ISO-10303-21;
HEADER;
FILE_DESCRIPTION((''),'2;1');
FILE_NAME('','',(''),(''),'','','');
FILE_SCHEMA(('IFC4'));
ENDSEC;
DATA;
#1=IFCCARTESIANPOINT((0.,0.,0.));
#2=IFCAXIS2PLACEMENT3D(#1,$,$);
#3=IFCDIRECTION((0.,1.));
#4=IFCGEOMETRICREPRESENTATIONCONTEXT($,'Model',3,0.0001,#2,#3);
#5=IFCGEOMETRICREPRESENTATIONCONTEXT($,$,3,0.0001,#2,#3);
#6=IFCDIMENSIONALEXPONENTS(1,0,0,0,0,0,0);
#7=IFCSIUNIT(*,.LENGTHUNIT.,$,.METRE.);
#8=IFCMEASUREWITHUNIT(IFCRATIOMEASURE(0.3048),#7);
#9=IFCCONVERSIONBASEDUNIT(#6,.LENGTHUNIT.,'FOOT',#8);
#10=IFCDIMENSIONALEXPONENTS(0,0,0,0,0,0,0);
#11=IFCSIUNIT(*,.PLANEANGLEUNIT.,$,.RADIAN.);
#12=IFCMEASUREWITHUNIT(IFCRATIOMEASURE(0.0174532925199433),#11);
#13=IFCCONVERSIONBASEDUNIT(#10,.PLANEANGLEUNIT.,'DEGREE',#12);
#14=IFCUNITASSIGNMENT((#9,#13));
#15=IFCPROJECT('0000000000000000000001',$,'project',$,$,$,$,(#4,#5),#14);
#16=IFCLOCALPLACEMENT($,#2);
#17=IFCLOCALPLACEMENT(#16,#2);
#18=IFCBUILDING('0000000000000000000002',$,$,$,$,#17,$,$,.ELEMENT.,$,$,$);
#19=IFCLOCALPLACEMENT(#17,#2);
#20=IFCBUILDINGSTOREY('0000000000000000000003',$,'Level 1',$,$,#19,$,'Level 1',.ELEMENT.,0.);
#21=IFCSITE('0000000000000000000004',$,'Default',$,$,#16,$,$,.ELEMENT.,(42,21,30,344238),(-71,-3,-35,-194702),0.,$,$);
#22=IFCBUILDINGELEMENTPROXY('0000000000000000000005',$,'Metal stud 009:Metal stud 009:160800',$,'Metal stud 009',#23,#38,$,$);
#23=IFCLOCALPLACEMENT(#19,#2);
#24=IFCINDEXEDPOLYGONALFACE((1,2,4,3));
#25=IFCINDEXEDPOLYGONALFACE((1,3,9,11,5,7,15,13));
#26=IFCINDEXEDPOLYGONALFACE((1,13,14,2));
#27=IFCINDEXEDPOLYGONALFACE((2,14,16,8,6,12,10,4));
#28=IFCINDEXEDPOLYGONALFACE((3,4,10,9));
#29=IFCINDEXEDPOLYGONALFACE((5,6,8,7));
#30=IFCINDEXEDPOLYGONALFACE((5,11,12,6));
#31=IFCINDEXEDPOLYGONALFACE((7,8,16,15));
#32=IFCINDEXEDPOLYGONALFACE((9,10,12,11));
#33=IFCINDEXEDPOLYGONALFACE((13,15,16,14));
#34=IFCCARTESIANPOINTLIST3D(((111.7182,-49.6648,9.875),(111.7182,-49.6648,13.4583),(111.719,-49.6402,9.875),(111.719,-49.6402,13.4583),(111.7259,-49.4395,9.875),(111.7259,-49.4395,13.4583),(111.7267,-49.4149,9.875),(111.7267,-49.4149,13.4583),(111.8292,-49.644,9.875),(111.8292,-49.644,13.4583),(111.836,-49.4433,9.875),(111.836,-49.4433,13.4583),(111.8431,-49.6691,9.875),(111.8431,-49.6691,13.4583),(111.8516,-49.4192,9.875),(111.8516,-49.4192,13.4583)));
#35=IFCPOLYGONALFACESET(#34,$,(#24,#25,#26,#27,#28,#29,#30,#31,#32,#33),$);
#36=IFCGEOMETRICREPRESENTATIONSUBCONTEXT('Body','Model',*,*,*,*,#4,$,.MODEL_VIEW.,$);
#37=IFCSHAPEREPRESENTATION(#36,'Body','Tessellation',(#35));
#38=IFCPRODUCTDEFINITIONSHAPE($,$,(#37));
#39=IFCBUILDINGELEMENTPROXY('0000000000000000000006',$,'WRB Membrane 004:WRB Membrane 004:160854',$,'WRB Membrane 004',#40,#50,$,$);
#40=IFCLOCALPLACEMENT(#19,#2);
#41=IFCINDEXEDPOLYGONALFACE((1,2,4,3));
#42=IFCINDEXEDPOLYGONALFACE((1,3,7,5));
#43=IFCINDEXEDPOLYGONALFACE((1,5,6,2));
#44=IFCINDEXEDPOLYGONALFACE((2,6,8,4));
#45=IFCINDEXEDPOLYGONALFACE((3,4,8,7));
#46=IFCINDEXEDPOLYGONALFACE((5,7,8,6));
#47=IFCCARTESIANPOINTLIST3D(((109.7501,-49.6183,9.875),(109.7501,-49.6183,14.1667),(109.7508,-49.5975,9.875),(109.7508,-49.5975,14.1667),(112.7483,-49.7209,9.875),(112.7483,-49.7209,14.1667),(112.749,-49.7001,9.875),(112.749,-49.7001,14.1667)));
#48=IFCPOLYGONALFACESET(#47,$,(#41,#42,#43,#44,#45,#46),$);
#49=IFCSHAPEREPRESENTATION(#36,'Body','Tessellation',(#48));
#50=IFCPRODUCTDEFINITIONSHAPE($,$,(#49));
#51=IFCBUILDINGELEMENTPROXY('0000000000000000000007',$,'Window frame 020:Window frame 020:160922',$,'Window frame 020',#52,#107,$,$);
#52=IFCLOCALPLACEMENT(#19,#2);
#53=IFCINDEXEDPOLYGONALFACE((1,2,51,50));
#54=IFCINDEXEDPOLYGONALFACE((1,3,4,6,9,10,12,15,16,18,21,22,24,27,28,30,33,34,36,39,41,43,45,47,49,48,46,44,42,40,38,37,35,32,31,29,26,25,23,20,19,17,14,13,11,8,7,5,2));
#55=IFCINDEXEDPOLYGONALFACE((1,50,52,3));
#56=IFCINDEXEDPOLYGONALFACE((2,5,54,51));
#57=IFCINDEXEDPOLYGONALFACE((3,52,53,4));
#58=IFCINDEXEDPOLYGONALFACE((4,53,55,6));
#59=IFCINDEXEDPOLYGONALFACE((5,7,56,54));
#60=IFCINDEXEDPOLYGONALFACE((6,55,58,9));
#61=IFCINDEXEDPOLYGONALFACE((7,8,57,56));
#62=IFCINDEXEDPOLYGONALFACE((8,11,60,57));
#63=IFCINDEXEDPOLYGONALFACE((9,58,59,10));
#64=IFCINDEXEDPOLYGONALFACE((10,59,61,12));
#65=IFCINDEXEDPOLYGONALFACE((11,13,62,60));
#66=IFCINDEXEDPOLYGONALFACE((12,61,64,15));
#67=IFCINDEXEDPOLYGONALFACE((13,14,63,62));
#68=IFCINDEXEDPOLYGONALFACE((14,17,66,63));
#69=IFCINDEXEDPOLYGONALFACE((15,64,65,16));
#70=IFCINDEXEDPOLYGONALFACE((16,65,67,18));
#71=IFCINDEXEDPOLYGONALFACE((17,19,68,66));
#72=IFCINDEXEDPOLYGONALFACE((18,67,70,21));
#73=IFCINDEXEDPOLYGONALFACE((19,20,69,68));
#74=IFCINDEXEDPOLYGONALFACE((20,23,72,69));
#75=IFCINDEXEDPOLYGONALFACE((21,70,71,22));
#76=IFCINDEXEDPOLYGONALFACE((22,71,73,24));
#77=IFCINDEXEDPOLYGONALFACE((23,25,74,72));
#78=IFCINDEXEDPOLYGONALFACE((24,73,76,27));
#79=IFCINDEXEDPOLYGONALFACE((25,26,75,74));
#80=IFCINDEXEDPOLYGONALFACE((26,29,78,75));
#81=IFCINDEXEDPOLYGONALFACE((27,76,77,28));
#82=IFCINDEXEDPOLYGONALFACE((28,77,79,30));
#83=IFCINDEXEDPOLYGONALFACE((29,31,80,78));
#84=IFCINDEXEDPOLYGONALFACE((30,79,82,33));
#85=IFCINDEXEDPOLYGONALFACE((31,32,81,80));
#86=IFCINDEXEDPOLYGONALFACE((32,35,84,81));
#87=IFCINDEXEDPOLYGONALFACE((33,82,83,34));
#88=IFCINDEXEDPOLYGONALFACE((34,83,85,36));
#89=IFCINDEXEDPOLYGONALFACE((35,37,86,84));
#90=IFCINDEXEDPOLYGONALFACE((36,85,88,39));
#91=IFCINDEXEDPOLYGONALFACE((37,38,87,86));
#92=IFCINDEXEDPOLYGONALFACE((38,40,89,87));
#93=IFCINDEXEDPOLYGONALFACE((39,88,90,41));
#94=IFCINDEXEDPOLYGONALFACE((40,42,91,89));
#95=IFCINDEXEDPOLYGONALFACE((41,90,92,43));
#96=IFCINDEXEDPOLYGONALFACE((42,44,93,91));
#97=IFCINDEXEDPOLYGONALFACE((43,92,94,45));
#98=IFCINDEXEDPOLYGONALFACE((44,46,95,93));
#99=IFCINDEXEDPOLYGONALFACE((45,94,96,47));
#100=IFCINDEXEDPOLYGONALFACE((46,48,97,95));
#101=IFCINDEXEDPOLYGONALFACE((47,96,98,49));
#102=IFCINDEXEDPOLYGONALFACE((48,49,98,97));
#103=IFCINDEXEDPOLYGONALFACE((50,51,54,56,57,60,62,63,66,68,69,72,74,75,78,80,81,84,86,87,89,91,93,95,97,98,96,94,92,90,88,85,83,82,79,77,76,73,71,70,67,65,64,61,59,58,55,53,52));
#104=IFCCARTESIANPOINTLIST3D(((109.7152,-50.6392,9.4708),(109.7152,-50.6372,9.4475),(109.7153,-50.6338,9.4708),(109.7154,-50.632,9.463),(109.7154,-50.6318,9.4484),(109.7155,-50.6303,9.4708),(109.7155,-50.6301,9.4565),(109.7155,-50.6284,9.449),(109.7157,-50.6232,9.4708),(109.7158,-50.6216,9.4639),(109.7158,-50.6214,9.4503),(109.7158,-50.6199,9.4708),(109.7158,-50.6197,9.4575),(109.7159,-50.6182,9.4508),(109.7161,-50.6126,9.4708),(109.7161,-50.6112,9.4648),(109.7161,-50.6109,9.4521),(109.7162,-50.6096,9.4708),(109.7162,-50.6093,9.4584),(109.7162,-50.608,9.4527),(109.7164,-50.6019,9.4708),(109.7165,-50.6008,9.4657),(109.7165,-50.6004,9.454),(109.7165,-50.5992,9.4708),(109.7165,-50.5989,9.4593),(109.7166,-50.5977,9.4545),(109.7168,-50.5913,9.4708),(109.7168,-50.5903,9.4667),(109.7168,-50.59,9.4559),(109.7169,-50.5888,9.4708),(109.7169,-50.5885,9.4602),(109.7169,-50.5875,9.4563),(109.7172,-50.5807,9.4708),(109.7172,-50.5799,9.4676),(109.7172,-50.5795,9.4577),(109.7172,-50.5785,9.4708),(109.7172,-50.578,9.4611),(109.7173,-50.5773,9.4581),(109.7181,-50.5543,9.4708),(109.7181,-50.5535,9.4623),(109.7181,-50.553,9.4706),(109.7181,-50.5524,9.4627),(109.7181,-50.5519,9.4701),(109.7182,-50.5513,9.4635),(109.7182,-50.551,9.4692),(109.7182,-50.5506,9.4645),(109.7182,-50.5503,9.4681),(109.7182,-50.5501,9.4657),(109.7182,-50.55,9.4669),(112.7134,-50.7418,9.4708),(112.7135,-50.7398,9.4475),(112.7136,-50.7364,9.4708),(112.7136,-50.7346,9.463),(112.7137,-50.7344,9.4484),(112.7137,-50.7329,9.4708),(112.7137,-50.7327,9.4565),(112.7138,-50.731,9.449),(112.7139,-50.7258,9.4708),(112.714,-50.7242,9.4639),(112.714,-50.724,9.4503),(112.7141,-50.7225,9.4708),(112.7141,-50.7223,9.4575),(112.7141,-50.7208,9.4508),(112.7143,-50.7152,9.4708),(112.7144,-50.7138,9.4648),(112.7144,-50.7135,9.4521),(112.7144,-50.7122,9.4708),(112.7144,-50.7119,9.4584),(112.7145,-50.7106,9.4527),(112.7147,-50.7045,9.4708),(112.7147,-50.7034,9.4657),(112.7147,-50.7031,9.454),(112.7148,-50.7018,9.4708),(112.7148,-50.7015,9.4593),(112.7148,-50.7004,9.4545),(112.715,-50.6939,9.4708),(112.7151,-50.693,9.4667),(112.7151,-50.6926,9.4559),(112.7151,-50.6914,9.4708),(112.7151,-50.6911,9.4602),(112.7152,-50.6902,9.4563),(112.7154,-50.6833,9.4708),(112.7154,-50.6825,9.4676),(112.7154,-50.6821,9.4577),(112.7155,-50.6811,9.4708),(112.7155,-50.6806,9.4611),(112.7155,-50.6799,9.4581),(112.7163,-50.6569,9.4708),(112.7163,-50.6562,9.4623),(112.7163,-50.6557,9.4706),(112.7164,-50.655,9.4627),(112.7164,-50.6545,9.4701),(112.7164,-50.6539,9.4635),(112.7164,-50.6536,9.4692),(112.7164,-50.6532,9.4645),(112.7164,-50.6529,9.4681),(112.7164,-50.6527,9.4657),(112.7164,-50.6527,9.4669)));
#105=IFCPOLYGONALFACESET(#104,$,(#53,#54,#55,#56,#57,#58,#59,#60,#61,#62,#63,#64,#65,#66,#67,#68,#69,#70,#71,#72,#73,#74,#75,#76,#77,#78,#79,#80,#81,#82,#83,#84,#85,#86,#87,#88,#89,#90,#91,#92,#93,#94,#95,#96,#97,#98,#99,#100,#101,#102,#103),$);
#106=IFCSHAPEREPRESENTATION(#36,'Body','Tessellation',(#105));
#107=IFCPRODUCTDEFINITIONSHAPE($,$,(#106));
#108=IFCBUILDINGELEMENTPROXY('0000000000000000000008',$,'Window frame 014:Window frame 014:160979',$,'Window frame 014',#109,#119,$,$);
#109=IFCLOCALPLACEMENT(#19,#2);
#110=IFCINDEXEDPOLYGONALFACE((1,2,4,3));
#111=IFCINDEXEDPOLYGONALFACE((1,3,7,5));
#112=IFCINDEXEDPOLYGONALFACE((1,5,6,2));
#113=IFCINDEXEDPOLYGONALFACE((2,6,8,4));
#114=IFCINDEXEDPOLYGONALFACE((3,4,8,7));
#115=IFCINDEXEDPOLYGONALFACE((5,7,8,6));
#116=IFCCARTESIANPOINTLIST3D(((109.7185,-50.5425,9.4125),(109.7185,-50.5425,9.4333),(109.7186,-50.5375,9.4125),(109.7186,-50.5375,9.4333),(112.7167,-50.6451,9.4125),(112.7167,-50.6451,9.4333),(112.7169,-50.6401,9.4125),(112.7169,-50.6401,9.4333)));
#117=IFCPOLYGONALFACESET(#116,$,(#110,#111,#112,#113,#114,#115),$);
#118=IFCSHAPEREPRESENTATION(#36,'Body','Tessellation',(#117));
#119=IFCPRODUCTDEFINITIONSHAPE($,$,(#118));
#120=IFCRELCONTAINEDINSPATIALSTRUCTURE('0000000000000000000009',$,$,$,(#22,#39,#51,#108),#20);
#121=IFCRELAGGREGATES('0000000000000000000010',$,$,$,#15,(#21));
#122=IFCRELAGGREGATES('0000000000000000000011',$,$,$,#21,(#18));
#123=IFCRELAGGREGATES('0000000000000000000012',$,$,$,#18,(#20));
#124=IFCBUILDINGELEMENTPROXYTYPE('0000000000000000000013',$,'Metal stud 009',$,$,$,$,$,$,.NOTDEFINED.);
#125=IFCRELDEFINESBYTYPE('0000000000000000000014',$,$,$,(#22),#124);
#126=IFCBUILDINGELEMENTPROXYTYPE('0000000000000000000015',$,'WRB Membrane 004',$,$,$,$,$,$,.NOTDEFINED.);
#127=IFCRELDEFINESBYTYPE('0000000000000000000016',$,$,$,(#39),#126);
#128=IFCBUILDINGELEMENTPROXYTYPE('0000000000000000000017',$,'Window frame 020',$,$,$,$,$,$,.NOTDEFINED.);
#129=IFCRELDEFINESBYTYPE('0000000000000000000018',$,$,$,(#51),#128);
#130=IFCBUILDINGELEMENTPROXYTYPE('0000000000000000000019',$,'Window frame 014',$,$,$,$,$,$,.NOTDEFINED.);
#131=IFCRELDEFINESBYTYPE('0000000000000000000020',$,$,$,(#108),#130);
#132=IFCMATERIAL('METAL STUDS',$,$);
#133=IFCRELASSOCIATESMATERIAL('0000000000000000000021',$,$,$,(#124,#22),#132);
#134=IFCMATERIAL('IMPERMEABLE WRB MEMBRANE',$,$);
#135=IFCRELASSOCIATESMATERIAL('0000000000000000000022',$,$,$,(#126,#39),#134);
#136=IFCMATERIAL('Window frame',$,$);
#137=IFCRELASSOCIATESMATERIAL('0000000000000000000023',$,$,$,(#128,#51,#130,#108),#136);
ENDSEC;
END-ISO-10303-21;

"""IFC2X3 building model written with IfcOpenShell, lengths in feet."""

from ifc_helpers import new_model, entity, si_unit, converted_unit, direction, frame, frame_2d, origin, origin_2d_with_axis, place, context, subcontext, project, spatial, polyline, circle_curve, parameter, trimmed, segment, composite_curve, rectangle, outline, extrude, source, transform, mapped, material, type_object, type_shapes, element, save


model = new_model("IFC2X3")

# Units and contexts
model_context = context("Model", 3, precision=0.0001, world=origin(), true_north=direction((0.0, 1.0)))
context_of_model = context(None, 3, precision=0.0001, world=origin(), true_north=direction((0.0, 1.0)))
body_context = subcontext(model_context, "Body", "Model", "MODEL_VIEW")
ifc_project = project(units=[converted_unit("LENGTHUNIT", "FOOT", entity("IfcRatioMeasure", 0.3048), si_unit("LENGTHUNIT", "METRE"), dimensions=[1, 0, 0, 0, 0, 0, 0]), converted_unit("PLANEANGLEUNIT", "DEGREE", entity("IfcRatioMeasure", 0.0174532925199433), si_unit("PLANEANGLEUNIT", "RADIAN"), dimensions=[0, 0, 0, 0, 0, 0, 0])], contexts=[model_context, context_of_model])

# Site, building, storey
site_placement = place(None, origin())
site = spatial("IfcSite", under=ifc_project, at=site_placement, Name="Default", CompositionType="ELEMENT", RefLatitude=(42, 21, 30, 344238), RefLongitude=(-71, -3, -35, -194702), RefElevation=0.0)
building_placement = place(site_placement, origin())
building = spatial("IfcBuilding", under=site, at=building_placement, CompositionType="ELEMENT")
storey_placement = place(building_placement, origin())
storey = spatial("IfcBuildingStorey", under=building, at=storey_placement, Name="Level 1", LongName="Level 1", CompositionType="ELEMENT", Elevation=0.0)

# Building element proxies
ifc_material_1 = material(Name="METAL STUDS")
building_element_proxy_type_1 = type_object("IfcBuildingElementProxyType", Name="Metal stud 009", PredefinedType="NOTDEFINED", material=ifc_material_1)
shared_shape_1 = source(origin(), body_context, "Body", "SweptSolid", [
    extrude(outline(polyline([(-0.0662, -0.125), (0.0588, -0.125), (0.0588, -0.1004), (-0.0514, -0.1004), (-0.0514, 0.1004), (0.0588, 0.1004), (0.0588, 0.125), (-0.0662, 0.125), (-0.0662, -0.125)])), frame((111.7812, -49.5419, 9.875), z_axis=(0.0, 0.0, 1.0), x_axis=(-0.999415, 0.034202, 0.0)), (0.0, 0.0, 1.0), 3.5833),
])
type_shapes(building_element_proxy_type_1, [shared_shape_1])
proxy_1_placement = place(storey_placement, origin())
element("IfcBuildingElementProxy", 1, at=proxy_1_placement, inside=storey, type_object=building_element_proxy_type_1, material=ifc_material_1, Name="Metal stud 009:Metal stud 009:160800", ObjectType="Metal stud 009", context=body_context, shape_type="MappedRepresentation", body=[
    mapped(shared_shape_1, transform((0.0, 0.0, 0.0), scale=1.0)),
])
ifc_material_2 = material(Name="IMPERMEABLE WRB MEMBRANE")
building_element_proxy_type_2 = type_object("IfcBuildingElementProxyType", Name="WRB Membrane 004", PredefinedType="NOTDEFINED", material=ifc_material_2)
shared_shape_2 = source(origin(), body_context, "Body", "SweptSolid", [
    extrude(rectangle(XDim=3.0, YDim=0.0208, at=origin_2d_with_axis()), frame((111.2496, -49.6592, 9.875), z_axis=(0.0, 0.0, 1.0), x_axis=(-0.999415, 0.034202, 0.0)), (0.0, 0.0, 1.0), 4.2917),
])
type_shapes(building_element_proxy_type_2, [shared_shape_2])
proxy_2_placement = place(storey_placement, origin())
element("IfcBuildingElementProxy", 2, at=proxy_2_placement, inside=storey, type_object=building_element_proxy_type_2, material=ifc_material_2, Name="WRB Membrane 004:WRB Membrane 004:160854", ObjectType="WRB Membrane 004", context=body_context, shape_type="MappedRepresentation", body=[
    mapped(shared_shape_2, transform((0.0, 0.0, 0.0), scale=1.0)),
])
ifc_material_3 = material(Name="Window frame")
building_element_proxy_type_3 = type_object("IfcBuildingElementProxyType", Name="Window frame 020", PredefinedType="NOTDEFINED", material=ifc_material_3)
shared_shape_3 = source(origin(), body_context, "Body", "SweptSolid", [
    extrude(outline(composite_curve([segment(polyline([(-0.0351, -0.0087), (-0.0297, -0.0087)]), True, "CONTINUOUS"), segment(polyline([(-0.0297, -0.0087), (-0.0266, -0.001)]), True, "CONTINUOUS"), segment(polyline([(-0.0266, -0.001), (-0.0262, -0.0087)]), True, "CONTINUOUS"), segment(polyline([(-0.0262, -0.0087), (-0.0191, -0.0087)]), True, "CONTINUOUS"), segment(polyline([(-0.0191, -0.0087), (-0.0161, -0.0019)]), True, "CONTINUOUS"), segment(polyline([(-0.0161, -0.0019), (-0.0158, -0.0087)]), True, "CONTINUOUS"), segment(polyline([(-0.0158, -0.0087), (-0.0084, -0.0087)]), True, "CONTINUOUS"), segment(polyline([(-0.0084, -0.0087), (-0.0057, -0.0028)]), True, "CONTINUOUS"), segment(polyline([(-0.0057, -0.0028), (-0.0054, -0.0087)]), True, "CONTINUOUS"), segment(polyline([(-0.0054, -0.0087), (0.0022, -0.0087)]), True, "CONTINUOUS"), segment(polyline([(0.0022, -0.0087), (0.0047, -0.0037)]), True, "CONTINUOUS"), segment(polyline([(0.0047, -0.0037), (0.0049, -0.0087)]), True, "CONTINUOUS"), segment(polyline([(0.0049, -0.0087), (0.0128, -0.0087)]), True, "CONTINUOUS"), segment(polyline([(0.0128, -0.0087), (0.0151, -0.0046)]), True, "CONTINUOUS"), segment(polyline([(0.0151, -0.0046), (0.0153, -0.0087)]), True, "CONTINUOUS"), segment(polyline([(0.0153, -0.0087), (0.0235, -0.0087)]), True, "CONTINUOUS"), segment(polyline([(0.0235, -0.0087), (0.0255, -0.0056)]), True, "CONTINUOUS"), segment(polyline([(0.0255, -0.0056), (0.0257, -0.0087)]), True, "CONTINUOUS"), segment(polyline([(0.0257, -0.0087), (0.0499, -0.0087)]), True, "CONTINUOUS"), segment(trimmed(circle_curve(frame_2d((0.0499, -0.0044), x_axis=(-0.984549, 0.175111)), 0.0043), [parameter(100.085127)], [parameter(269.994873)], True, "PARAMETER"), True, "CONTINUOUS"), segment(polyline([(0.0506, -0.0002), (0.0268, 0.004)]), True, "CONTINUOUS"), segment(polyline([(0.0268, 0.004), (0.0248, 0.0011)]), True, "CONTINUOUS"), segment(polyline([(0.0248, 0.0011), (0.0246, 0.0044)]), True, "CONTINUOUS"), segment(polyline([(0.0246, 0.0044), (0.0166, 0.0058)]), True, "CONTINUOUS"), segment(polyline([(0.0166, 0.0058), (0.0144, 0.002)]), True, "CONTINUOUS"), segment(polyline([(0.0144, 0.002), (0.0142, 0.0063)]), True, "CONTINUOUS"), segment(polyline([(0.0142, 0.0063), (0.0064, 0.0077)]), True, "CONTINUOUS"), segment(polyline([(0.0064, 0.0077), (0.004, 0.003)]), True, "CONTINUOUS"), segment(polyline([(0.004, 0.003), (0.0037, 0.0081)]), True, "CONTINUOUS"), segment(polyline([(0.0037, 0.0081), (-0.0038, 0.0095)]), True, "CONTINUOUS"), segment(polyline([(-0.0038, 0.0095), (-0.0065, 0.0039)]), True, "CONTINUOUS"), segment(polyline([(-0.0065, 0.0039), (-0.0068, 0.01)]), True, "CONTINUOUS"), segment(polyline([(-0.0068, 0.01), (-0.014, 0.0113)]), True, "CONTINUOUS"), segment(polyline([(-0.014, 0.0113), (-0.0169, 0.0048)]), True, "CONTINUOUS"), segment(polyline([(-0.0169, 0.0048), (-0.0172, 0.0119)]), True, "CONTINUOUS"), segment(polyline([(-0.0172, 0.0119), (-0.0242, 0.0131)]), True, "CONTINUOUS"), segment(polyline([(-0.0242, 0.0131), (-0.0273, 0.0057)]), True, "CONTINUOUS"), segment(polyline([(-0.0273, 0.0057), (-0.0277, 0.0137)]), True, "CONTINUOUS"), segment(polyline([(-0.0277, 0.0137), (-0.0331, 0.0147)]), True, "CONTINUOUS"), segment(polyline([(-0.0331, 0.0147), (-0.0351, -0.0087)]), True, "CONTINUOUS")], self_intersect=False)), frame((109.7164, -50.6041, 9.4621), z_axis=(0.999415, -0.034202, 0.0), x_axis=(0.033673, 0.983973, 0.175111)), (0.0, 0.0, 1.0), 3.0),
])
type_shapes(building_element_proxy_type_3, [shared_shape_3])
proxy_3_placement = place(storey_placement, origin())
element("IfcBuildingElementProxy", 3, at=proxy_3_placement, inside=storey, type_object=building_element_proxy_type_3, material=ifc_material_3, Name="Window frame 020:Window frame 020:160922", ObjectType="Window frame 020", context=body_context, shape_type="MappedRepresentation", body=[
    mapped(shared_shape_3, transform((0.0, 0.0, 0.0), scale=1.0)),
])
building_element_proxy_type_4 = type_object("IfcBuildingElementProxyType", Name="Window frame 014", PredefinedType="NOTDEFINED", material=ifc_material_3)
shared_shape_4 = source(origin(), body_context, "Body", "SweptSolid", [
    extrude(rectangle(XDim=3.0, YDim=0.005, at=frame_2d((0.0, 0.0), x_axis=(1.0, 0.0))), frame((111.2177, -50.5913, 9.4125), z_axis=(0.0, 0.0, 1.0), x_axis=(-0.999415, 0.034202, 0.0)), (0.0, 0.0, 1.0), 0.0208),
])
type_shapes(building_element_proxy_type_4, [shared_shape_4])
proxy_4_placement = place(storey_placement, origin())
element("IfcBuildingElementProxy", 4, at=proxy_4_placement, inside=storey, type_object=building_element_proxy_type_4, material=ifc_material_3, Name="Window frame 014:Window frame 014:160979", ObjectType="Window frame 014", context=body_context, shape_type="MappedRepresentation", body=[
    mapped(shared_shape_4, transform((0.0, 0.0, 0.0), scale=1.0)),
])

save(model, "model.ifc")
